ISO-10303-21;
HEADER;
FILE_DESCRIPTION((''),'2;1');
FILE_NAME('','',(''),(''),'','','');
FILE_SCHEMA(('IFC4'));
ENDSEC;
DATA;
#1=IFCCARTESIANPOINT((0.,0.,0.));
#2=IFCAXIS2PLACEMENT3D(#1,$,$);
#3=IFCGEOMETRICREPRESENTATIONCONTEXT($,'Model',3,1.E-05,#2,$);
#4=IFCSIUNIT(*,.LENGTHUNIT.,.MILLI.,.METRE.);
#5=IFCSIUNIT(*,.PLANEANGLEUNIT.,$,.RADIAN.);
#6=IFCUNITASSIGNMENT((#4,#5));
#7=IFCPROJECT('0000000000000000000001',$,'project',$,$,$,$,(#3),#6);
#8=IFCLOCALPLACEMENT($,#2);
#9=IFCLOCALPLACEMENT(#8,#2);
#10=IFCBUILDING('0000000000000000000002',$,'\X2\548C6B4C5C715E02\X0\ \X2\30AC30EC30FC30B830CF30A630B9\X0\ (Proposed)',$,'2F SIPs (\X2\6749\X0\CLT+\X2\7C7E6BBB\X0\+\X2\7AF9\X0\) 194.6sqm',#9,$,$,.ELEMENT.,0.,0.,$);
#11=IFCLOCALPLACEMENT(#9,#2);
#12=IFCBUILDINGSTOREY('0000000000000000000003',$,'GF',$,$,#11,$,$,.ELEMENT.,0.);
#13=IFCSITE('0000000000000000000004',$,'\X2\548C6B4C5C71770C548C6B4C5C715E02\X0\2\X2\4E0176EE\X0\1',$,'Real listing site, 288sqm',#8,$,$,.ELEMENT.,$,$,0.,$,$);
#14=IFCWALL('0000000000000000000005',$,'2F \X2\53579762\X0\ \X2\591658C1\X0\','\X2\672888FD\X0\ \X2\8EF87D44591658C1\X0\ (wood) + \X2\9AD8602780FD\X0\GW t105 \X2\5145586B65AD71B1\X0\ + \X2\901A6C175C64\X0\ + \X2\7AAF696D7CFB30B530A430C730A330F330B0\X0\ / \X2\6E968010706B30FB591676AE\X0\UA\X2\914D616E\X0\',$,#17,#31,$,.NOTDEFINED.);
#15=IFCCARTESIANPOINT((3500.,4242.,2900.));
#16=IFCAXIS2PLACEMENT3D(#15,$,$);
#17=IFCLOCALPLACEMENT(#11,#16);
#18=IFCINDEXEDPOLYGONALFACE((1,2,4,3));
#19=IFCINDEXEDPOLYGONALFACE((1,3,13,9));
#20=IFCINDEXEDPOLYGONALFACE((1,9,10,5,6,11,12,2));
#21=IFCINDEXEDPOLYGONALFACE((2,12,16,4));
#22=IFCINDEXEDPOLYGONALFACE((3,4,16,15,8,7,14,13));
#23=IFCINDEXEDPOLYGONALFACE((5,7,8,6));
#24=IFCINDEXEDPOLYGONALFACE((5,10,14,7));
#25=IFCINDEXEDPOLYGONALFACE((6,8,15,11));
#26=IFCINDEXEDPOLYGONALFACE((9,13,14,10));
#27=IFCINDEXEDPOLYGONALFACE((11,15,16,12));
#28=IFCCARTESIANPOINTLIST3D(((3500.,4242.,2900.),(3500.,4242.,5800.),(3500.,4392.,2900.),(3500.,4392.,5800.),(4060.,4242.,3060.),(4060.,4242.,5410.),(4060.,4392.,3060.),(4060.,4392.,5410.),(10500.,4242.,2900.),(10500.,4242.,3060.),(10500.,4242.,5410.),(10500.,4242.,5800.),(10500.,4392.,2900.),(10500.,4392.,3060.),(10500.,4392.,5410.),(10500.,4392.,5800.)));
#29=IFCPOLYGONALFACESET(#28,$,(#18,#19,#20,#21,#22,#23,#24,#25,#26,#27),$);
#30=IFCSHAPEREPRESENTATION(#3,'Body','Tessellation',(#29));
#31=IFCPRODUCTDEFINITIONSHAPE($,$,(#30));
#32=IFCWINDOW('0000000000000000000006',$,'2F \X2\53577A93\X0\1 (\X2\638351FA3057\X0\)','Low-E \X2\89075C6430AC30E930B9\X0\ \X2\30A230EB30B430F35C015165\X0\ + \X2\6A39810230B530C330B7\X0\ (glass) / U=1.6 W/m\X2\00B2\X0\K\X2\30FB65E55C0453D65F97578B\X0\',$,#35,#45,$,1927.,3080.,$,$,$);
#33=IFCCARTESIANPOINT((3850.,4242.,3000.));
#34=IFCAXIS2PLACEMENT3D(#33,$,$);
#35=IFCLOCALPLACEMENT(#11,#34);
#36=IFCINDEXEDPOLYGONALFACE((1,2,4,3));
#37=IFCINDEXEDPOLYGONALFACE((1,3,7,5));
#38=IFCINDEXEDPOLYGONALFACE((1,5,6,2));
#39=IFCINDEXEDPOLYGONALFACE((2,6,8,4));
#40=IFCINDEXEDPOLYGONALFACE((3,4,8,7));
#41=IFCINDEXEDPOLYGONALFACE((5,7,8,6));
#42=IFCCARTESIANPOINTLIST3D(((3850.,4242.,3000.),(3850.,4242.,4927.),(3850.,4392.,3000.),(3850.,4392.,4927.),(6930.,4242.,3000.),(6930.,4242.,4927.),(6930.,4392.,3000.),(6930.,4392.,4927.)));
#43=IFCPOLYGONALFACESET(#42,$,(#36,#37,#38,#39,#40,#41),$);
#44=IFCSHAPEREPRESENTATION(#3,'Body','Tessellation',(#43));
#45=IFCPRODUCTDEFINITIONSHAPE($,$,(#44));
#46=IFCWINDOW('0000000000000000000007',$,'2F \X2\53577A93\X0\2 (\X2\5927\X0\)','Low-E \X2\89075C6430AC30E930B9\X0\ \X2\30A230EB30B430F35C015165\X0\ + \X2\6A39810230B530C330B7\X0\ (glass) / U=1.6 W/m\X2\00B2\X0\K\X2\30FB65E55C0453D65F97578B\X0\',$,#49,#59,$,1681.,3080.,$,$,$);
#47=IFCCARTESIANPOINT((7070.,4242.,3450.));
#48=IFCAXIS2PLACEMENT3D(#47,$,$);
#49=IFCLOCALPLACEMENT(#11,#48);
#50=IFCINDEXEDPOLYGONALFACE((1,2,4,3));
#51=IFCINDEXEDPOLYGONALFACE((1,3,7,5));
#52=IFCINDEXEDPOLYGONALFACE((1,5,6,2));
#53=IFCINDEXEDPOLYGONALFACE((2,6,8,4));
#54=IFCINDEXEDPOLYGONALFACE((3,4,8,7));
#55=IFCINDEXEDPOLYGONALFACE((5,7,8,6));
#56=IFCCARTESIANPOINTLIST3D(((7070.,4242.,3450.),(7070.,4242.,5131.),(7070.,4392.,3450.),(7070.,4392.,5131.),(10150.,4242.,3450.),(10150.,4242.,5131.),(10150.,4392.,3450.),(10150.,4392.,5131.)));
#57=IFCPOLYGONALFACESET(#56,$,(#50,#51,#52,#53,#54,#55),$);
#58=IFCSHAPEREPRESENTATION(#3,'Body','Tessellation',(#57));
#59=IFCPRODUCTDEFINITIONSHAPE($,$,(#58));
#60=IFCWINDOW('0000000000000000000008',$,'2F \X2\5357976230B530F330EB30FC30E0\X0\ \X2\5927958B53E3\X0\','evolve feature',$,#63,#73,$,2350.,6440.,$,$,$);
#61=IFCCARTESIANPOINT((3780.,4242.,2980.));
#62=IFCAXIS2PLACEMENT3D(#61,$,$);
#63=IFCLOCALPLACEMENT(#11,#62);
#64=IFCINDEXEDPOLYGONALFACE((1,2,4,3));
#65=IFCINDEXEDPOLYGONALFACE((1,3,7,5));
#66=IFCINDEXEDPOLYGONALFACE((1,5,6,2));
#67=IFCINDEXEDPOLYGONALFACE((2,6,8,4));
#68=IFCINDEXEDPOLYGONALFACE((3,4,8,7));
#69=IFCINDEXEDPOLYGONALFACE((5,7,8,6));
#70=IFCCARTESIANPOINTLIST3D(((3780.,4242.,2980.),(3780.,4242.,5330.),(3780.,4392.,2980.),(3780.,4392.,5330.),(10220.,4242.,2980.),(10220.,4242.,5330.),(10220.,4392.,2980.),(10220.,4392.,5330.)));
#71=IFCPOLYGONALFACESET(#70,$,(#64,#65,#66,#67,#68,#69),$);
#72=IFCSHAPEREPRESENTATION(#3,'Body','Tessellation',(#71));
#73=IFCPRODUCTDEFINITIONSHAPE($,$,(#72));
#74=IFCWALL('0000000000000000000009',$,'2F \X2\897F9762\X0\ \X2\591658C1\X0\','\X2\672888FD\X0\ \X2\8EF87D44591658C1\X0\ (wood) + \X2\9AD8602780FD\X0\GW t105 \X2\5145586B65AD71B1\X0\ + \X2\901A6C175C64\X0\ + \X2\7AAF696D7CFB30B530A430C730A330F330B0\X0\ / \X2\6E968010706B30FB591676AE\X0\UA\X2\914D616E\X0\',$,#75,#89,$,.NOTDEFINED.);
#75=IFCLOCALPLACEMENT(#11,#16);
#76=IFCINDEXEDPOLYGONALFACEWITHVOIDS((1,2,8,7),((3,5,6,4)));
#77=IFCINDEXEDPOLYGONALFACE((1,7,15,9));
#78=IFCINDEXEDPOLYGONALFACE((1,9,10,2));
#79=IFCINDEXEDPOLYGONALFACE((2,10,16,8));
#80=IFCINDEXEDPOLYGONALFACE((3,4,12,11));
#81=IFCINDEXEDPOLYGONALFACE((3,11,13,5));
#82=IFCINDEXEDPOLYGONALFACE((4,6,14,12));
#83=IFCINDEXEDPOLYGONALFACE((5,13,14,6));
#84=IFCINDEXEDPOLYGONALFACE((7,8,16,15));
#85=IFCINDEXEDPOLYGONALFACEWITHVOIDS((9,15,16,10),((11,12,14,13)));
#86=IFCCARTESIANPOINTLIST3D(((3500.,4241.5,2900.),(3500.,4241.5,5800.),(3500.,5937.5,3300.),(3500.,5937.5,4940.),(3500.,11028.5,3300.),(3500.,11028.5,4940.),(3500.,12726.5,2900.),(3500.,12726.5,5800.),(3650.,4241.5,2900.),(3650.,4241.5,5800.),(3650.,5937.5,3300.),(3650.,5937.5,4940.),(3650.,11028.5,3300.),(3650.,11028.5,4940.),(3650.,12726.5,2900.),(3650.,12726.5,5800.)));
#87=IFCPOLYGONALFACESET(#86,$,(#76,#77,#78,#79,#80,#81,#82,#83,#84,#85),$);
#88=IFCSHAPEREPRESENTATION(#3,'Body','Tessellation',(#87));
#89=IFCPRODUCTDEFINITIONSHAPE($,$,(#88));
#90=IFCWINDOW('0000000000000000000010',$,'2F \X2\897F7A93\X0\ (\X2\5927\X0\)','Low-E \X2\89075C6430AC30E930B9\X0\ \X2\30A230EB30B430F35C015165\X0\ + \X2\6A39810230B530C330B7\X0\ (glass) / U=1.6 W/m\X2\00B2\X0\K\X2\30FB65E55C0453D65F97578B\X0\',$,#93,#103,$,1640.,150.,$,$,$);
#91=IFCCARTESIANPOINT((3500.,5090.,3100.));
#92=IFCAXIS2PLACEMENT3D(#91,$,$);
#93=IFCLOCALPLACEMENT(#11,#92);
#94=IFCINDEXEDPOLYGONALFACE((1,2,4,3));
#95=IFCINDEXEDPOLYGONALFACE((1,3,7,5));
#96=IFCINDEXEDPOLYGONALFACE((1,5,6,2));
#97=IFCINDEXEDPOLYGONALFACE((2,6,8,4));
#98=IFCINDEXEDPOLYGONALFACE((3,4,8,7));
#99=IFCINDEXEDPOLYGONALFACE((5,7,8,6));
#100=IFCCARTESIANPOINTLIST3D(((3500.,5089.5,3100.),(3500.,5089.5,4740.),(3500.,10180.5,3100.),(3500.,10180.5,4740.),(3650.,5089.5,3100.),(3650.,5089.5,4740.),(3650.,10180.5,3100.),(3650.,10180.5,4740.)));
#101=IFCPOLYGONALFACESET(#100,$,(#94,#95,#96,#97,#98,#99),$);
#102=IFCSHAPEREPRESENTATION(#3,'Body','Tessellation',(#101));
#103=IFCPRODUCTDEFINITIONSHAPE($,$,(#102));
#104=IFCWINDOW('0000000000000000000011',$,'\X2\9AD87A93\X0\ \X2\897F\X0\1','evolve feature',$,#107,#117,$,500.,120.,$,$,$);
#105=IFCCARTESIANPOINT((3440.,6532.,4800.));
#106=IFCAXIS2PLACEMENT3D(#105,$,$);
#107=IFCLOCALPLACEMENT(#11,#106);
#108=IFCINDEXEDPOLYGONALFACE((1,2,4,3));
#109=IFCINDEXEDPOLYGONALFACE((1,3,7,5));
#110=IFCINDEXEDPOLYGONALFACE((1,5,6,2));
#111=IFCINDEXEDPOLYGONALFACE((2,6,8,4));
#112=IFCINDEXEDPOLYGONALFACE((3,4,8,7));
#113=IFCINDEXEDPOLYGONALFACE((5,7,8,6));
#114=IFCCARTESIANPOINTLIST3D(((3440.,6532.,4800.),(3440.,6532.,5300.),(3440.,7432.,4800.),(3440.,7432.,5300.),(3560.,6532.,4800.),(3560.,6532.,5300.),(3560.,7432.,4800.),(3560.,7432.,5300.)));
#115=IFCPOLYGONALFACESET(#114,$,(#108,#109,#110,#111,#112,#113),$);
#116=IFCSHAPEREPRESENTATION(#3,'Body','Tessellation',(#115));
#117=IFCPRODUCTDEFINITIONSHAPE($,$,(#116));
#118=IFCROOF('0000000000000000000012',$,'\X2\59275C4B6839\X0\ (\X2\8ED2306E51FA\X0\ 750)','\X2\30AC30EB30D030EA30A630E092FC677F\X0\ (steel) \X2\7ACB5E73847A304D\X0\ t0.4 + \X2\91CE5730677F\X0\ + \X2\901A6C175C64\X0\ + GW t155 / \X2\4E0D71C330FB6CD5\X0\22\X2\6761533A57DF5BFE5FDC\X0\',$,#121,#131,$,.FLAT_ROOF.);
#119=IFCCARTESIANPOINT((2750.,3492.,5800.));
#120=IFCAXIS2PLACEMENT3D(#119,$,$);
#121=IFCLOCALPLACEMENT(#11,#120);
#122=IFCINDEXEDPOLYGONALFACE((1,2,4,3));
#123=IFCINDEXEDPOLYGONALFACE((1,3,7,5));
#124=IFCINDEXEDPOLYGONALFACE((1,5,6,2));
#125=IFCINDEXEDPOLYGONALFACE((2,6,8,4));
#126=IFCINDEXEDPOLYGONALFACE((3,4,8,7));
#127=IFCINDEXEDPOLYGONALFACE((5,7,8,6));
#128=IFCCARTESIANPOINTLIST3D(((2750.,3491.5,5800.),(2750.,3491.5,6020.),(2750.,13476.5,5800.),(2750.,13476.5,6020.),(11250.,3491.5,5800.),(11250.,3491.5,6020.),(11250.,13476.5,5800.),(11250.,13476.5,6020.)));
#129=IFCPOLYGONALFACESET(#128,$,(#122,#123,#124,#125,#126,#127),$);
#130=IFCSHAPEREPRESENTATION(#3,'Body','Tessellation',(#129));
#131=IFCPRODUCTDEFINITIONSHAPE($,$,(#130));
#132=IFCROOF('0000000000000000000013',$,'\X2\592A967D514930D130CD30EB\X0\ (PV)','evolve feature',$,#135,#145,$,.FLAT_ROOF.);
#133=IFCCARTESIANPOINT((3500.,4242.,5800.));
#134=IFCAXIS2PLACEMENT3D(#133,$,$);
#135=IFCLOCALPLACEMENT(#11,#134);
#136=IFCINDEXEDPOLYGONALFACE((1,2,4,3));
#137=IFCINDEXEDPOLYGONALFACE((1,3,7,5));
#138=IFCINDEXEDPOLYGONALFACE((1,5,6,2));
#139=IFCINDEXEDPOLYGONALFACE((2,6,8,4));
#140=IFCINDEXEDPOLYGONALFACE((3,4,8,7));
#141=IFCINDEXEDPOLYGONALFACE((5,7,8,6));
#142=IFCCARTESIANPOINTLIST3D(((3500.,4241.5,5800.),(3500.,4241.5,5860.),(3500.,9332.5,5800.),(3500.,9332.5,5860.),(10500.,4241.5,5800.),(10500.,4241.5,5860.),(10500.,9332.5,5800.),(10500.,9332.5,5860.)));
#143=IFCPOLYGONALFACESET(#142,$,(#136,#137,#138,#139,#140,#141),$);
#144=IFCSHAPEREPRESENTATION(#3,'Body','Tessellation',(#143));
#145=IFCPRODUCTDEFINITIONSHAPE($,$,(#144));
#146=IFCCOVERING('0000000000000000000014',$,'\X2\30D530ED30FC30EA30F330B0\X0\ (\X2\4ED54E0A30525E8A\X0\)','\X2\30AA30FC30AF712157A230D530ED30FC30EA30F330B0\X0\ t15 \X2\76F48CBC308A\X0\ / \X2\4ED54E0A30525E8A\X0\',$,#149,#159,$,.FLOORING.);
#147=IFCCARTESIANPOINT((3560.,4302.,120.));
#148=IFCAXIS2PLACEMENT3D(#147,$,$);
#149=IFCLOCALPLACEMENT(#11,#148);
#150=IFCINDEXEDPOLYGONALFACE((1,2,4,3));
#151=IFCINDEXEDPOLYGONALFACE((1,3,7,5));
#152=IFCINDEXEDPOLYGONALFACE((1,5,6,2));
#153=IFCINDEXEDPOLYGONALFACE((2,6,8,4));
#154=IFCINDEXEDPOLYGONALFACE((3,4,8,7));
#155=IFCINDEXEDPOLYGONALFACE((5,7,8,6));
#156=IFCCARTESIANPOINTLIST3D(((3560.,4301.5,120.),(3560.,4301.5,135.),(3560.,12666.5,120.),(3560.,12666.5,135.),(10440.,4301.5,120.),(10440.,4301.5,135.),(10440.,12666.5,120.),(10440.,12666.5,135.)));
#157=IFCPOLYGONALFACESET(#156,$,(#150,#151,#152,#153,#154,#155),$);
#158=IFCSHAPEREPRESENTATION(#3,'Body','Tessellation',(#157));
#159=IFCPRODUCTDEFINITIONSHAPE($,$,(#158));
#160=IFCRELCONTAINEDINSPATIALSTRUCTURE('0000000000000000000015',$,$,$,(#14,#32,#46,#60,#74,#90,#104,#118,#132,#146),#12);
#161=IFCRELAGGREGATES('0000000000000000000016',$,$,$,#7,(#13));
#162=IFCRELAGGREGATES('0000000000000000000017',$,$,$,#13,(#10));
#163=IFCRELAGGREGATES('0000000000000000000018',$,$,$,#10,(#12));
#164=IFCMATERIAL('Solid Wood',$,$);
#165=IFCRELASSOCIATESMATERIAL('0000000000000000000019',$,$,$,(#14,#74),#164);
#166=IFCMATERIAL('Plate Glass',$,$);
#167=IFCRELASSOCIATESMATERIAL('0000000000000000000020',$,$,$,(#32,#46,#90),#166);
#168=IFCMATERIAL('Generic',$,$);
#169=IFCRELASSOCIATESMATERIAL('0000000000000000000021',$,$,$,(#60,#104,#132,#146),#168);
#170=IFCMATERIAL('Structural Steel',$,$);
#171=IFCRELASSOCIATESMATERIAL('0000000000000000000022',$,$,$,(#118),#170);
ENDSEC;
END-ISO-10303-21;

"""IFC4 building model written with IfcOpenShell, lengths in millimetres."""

from ifc_helpers import new_model, si_unit, frame, frame_2d, origin, place, context, project, spatial, rectangle, extrude, material, element, fill, save


model = new_model("IFC4")

# Units and contexts
model_context = context("Model", 3, precision=1e-05, world=origin())
ifc_project = project(units=[si_unit("LENGTHUNIT", "METRE", prefix="MILLI"), si_unit("PLANEANGLEUNIT", "RADIAN")], contexts=[model_context])

# Site, building, storey
site_placement = place(None, origin())
site = spatial("IfcSite", under=ifc_project, at=site_placement, Name="和歌山県和歌山市2丁目1", ObjectType="Real listing site, 288sqm", CompositionType="ELEMENT", RefElevation=0.0)
building_placement = place(site_placement, origin())
building = spatial("IfcBuilding", under=site, at=building_placement, Name="和歌山市 ガレージハウス (Proposed)", ObjectType="2F SIPs (杉CLT+籾殻+竹) 194.6sqm", CompositionType="ELEMENT", ElevationOfRefHeight=0.0, ElevationOfTerrain=0.0)
storey_placement = place(building_placement, origin())
storey = spatial("IfcBuildingStorey", under=building, at=storey_placement, Name="GF", CompositionType="ELEMENT", Elevation=0.0)

# Shared definitions
ifc_material_1 = material(Name="Solid Wood")

# Shared definitions
ifc_material_2 = material(Name="Plate Glass")
ifc_material_3 = material(Name="Generic")

# Walls, openings, windows
wall_1_placement = place(storey_placement, frame((3500.0, 4242.0, 2900.0)))
wall_1 = element("IfcWall", 1, at=wall_1_placement, inside=storey, material=ifc_material_1, Name="2F 南面 外壁", Description="木製 軸組外壁 (wood) + 高性能GW t105 充填断熱 + 通気層 + 窯業系サイディング / 準耐火・外皮UA配慮", PredefinedType="NOTDEFINED", context=model_context, shape_type="SweptSolid", body=[
    extrude(rectangle(XDim=7000.0, YDim=150.0, at=frame_2d((3500.0, 75.0))), frame((3500.0, 4242.0, 2900.0)), (0.0, 0.0, 1.0), 2900.0),
])
opening_1_placement = place(storey_placement, frame((3850.0, 4242.0, 3000.0)))
opening_1 = element("IfcOpeningElement", 2, at=opening_1_placement, cuts=wall_1, PredefinedType="NOTDEFINED", context=model_context, shape_type="SweptSolid", body=[
    extrude(rectangle(XDim=3080.0, YDim=150.0, at=frame_2d((1540.0, 75.0))), frame((3850.0, 4242.0, 3000.0)), (0.0, 0.0, 1.0), 1927.0),
])
opening_2_placement = place(storey_placement, frame((7070.0, 4242.0, 3450.0)))
opening_2 = element("IfcOpeningElement", 3, at=opening_2_placement, cuts=wall_1, PredefinedType="NOTDEFINED", context=model_context, shape_type="SweptSolid", body=[
    extrude(rectangle(XDim=3080.0, YDim=150.0, at=frame_2d((1540.0, 75.0))), frame((7070.0, 4242.0, 3450.0)), (0.0, 0.0, 1.0), 1681.0),
])
opening_3_placement = place(storey_placement, frame((3780.0, 4242.0, 2980.0)))
opening_3 = element("IfcOpeningElement", 4, at=opening_3_placement, cuts=wall_1, PredefinedType="NOTDEFINED", context=model_context, shape_type="SweptSolid", body=[
    extrude(rectangle(XDim=6440.0, YDim=150.0, at=frame_2d((3220.0, 75.0))), frame((3780.0, 4242.0, 2980.0)), (0.0, 0.0, 1.0), 2350.0),
])
window_1_placement = place(storey_placement, frame((3850.0, 4242.0, 3000.0)))
window_1 = element("IfcWindow", 5, at=window_1_placement, inside=storey, material=ifc_material_2, Name="2F 南窓1 (掃出し)", Description="Low-E 複層ガラス アルゴン封入 + 樹脂サッシ (glass) / U=1.6 W/m²K・日射取得型", OverallHeight=1927.0, OverallWidth=3080.0, context=model_context, shape_type="SweptSolid", body=[
    extrude(rectangle(XDim=3080.0, YDim=150.0, at=frame_2d((1540.0, 75.0))), frame((3850.0, 4242.0, 3000.0)), (0.0, 0.0, 1.0), 1927.0),
])
fill(opening_1, window_1)
window_2_placement = place(storey_placement, frame((7070.0, 4242.0, 3450.0)))
window_2 = element("IfcWindow", 6, at=window_2_placement, inside=storey, material=ifc_material_2, Name="2F 南窓2 (大)", Description="Low-E 複層ガラス アルゴン封入 + 樹脂サッシ (glass) / U=1.6 W/m²K・日射取得型", OverallHeight=1681.0, OverallWidth=3080.0, context=model_context, shape_type="SweptSolid", body=[
    extrude(rectangle(XDim=3080.0, YDim=150.0, at=frame_2d((1540.0, 75.0))), frame((7070.0, 4242.0, 3450.0)), (0.0, 0.0, 1.0), 1681.0),
])
fill(opening_2, window_2)
window_3_placement = place(storey_placement, frame((3780.0, 4242.0, 2980.0)))
window_3 = element("IfcWindow", 7, at=window_3_placement, inside=storey, material=ifc_material_3, Name="2F 南面サンルーム 大開口", Description="evolve feature", OverallHeight=2350.0, OverallWidth=6440.0, context=model_context, shape_type="SweptSolid", body=[
    extrude(rectangle(XDim=6440.0, YDim=150.0, at=frame_2d((3220.0, 75.0))), frame((3780.0, 4242.0, 2980.0)), (0.0, 0.0, 1.0), 2350.0),
])
fill(opening_3, window_3)
wall_2_placement = place(storey_placement, frame((3500.0, 4242.0, 2900.0)))
wall_2 = element("IfcWall", 8, at=wall_2_placement, inside=storey, material=ifc_material_1, Name="2F 西面 外壁", Description="木製 軸組外壁 (wood) + 高性能GW t105 充填断熱 + 通気層 + 窯業系サイディング / 準耐火・外皮UA配慮", PredefinedType="NOTDEFINED", context=model_context, shape_type="SweptSolid", body=[
    extrude(rectangle(XDim=150.0, YDim=8485.0, at=frame_2d((75.0, 4242.0))), frame((3500.0, 4242.0, 2900.0)), (0.0, 0.0, 1.0), 2900.0),
])
opening_4_placement = place(storey_placement, frame((3500.0, 5090.0, 3100.0)))
opening_4 = element("IfcOpeningElement", 9, at=opening_4_placement, cuts=wall_2, PredefinedType="NOTDEFINED", context=model_context, shape_type="SweptSolid", body=[
    extrude(rectangle(XDim=150.0, YDim=5091.0, at=frame_2d((75.0, 2545.0))), frame((3500.0, 5090.0, 3100.0)), (0.0, 0.0, 1.0), 1640.0),
])
opening_5_placement = place(storey_placement, frame((3440.0, 6532.0, 4800.0)))
opening_5 = element("IfcOpeningElement", 10, at=opening_5_placement, cuts=wall_2, PredefinedType="NOTDEFINED", context=model_context, shape_type="SweptSolid", body=[
    extrude(rectangle(XDim=120.0, YDim=900.0, at=frame_2d((60.0, 450.0))), frame((3440.0, 6532.0, 4800.0)), (0.0, 0.0, 1.0), 500.0),
])
window_4_placement = place(storey_placement, frame((3500.0, 5090.0, 3100.0)))
window_4 = element("IfcWindow", 11, at=window_4_placement, inside=storey, material=ifc_material_2, Name="2F 西窓 (大)", Description="Low-E 複層ガラス アルゴン封入 + 樹脂サッシ (glass) / U=1.6 W/m²K・日射取得型", OverallHeight=1640.0, OverallWidth=150.0, context=model_context, shape_type="SweptSolid", body=[
    extrude(rectangle(XDim=150.0, YDim=5091.0, at=frame_2d((75.0, 2545.0))), frame((3500.0, 5090.0, 3100.0)), (0.0, 0.0, 1.0), 1640.0),
])
fill(opening_4, window_4)
window_5_placement = place(storey_placement, frame((3440.0, 6532.0, 4800.0)))
window_5 = element("IfcWindow", 12, at=window_5_placement, inside=storey, material=ifc_material_3, Name="高窓 西1", Description="evolve feature", OverallHeight=500.0, OverallWidth=120.0, context=model_context, shape_type="SweptSolid", body=[
    extrude(rectangle(XDim=120.0, YDim=900.0, at=frame_2d((60.0, 450.0))), frame((3440.0, 6532.0, 4800.0)), (0.0, 0.0, 1.0), 500.0),
])
fill(opening_5, window_5)

# Roofs
ifc_material_4 = material(Name="Structural Steel")
roof_1_placement = place(storey_placement, frame((2750.0, 3492.0, 5800.0)))
element("IfcRoof", 13, at=roof_1_placement, inside=storey, material=ifc_material_4, Name="大屋根 (軒の出 750)", Description="ガルバリウム鋼板 (steel) 立平葺き t0.4 + 野地板 + 通気層 + GW t155 / 不燃・法22条区域対応", PredefinedType="FLAT_ROOF", context=model_context, shape_type="SweptSolid", body=[
    extrude(rectangle(XDim=8500.0, YDim=9985.0, at=frame_2d((4250.0, 4992.0))), frame((2750.0, 3492.0, 5800.0)), (0.0, 0.0, 1.0), 220.0),
])
roof_2_placement = place(storey_placement, frame((3500.0, 4242.0, 5800.0)))
element("IfcRoof", 14, at=roof_2_placement, inside=storey, material=ifc_material_3, Name="太陽光パネル (PV)", Description="evolve feature", PredefinedType="FLAT_ROOF", context=model_context, shape_type="SweptSolid", body=[
    extrude(rectangle(XDim=7000.0, YDim=5091.0, at=frame_2d((3500.0, 2545.0))), frame((3500.0, 4242.0, 5800.0)), (0.0, 0.0, 1.0), 60.0),
])

# Covering
covering_placement = place(storey_placement, frame((3560.0, 4302.0, 120.0)))
element("IfcCovering", 15, at=covering_placement, inside=storey, material=ifc_material_3, Name="フローリング (仕上げ床)", Description="オーク無垢フローリング t15 直貼り / 仕上げ床", PredefinedType="FLOORING", context=model_context, shape_type="SweptSolid", body=[
    extrude(rectangle(XDim=6880.0, YDim=8365.0, at=frame_2d((3440.0, 4182.0))), frame((3560.0, 4302.0, 120.0)), (0.0, 0.0, 1.0), 15.0),
])

save(model, "model.ifc")
